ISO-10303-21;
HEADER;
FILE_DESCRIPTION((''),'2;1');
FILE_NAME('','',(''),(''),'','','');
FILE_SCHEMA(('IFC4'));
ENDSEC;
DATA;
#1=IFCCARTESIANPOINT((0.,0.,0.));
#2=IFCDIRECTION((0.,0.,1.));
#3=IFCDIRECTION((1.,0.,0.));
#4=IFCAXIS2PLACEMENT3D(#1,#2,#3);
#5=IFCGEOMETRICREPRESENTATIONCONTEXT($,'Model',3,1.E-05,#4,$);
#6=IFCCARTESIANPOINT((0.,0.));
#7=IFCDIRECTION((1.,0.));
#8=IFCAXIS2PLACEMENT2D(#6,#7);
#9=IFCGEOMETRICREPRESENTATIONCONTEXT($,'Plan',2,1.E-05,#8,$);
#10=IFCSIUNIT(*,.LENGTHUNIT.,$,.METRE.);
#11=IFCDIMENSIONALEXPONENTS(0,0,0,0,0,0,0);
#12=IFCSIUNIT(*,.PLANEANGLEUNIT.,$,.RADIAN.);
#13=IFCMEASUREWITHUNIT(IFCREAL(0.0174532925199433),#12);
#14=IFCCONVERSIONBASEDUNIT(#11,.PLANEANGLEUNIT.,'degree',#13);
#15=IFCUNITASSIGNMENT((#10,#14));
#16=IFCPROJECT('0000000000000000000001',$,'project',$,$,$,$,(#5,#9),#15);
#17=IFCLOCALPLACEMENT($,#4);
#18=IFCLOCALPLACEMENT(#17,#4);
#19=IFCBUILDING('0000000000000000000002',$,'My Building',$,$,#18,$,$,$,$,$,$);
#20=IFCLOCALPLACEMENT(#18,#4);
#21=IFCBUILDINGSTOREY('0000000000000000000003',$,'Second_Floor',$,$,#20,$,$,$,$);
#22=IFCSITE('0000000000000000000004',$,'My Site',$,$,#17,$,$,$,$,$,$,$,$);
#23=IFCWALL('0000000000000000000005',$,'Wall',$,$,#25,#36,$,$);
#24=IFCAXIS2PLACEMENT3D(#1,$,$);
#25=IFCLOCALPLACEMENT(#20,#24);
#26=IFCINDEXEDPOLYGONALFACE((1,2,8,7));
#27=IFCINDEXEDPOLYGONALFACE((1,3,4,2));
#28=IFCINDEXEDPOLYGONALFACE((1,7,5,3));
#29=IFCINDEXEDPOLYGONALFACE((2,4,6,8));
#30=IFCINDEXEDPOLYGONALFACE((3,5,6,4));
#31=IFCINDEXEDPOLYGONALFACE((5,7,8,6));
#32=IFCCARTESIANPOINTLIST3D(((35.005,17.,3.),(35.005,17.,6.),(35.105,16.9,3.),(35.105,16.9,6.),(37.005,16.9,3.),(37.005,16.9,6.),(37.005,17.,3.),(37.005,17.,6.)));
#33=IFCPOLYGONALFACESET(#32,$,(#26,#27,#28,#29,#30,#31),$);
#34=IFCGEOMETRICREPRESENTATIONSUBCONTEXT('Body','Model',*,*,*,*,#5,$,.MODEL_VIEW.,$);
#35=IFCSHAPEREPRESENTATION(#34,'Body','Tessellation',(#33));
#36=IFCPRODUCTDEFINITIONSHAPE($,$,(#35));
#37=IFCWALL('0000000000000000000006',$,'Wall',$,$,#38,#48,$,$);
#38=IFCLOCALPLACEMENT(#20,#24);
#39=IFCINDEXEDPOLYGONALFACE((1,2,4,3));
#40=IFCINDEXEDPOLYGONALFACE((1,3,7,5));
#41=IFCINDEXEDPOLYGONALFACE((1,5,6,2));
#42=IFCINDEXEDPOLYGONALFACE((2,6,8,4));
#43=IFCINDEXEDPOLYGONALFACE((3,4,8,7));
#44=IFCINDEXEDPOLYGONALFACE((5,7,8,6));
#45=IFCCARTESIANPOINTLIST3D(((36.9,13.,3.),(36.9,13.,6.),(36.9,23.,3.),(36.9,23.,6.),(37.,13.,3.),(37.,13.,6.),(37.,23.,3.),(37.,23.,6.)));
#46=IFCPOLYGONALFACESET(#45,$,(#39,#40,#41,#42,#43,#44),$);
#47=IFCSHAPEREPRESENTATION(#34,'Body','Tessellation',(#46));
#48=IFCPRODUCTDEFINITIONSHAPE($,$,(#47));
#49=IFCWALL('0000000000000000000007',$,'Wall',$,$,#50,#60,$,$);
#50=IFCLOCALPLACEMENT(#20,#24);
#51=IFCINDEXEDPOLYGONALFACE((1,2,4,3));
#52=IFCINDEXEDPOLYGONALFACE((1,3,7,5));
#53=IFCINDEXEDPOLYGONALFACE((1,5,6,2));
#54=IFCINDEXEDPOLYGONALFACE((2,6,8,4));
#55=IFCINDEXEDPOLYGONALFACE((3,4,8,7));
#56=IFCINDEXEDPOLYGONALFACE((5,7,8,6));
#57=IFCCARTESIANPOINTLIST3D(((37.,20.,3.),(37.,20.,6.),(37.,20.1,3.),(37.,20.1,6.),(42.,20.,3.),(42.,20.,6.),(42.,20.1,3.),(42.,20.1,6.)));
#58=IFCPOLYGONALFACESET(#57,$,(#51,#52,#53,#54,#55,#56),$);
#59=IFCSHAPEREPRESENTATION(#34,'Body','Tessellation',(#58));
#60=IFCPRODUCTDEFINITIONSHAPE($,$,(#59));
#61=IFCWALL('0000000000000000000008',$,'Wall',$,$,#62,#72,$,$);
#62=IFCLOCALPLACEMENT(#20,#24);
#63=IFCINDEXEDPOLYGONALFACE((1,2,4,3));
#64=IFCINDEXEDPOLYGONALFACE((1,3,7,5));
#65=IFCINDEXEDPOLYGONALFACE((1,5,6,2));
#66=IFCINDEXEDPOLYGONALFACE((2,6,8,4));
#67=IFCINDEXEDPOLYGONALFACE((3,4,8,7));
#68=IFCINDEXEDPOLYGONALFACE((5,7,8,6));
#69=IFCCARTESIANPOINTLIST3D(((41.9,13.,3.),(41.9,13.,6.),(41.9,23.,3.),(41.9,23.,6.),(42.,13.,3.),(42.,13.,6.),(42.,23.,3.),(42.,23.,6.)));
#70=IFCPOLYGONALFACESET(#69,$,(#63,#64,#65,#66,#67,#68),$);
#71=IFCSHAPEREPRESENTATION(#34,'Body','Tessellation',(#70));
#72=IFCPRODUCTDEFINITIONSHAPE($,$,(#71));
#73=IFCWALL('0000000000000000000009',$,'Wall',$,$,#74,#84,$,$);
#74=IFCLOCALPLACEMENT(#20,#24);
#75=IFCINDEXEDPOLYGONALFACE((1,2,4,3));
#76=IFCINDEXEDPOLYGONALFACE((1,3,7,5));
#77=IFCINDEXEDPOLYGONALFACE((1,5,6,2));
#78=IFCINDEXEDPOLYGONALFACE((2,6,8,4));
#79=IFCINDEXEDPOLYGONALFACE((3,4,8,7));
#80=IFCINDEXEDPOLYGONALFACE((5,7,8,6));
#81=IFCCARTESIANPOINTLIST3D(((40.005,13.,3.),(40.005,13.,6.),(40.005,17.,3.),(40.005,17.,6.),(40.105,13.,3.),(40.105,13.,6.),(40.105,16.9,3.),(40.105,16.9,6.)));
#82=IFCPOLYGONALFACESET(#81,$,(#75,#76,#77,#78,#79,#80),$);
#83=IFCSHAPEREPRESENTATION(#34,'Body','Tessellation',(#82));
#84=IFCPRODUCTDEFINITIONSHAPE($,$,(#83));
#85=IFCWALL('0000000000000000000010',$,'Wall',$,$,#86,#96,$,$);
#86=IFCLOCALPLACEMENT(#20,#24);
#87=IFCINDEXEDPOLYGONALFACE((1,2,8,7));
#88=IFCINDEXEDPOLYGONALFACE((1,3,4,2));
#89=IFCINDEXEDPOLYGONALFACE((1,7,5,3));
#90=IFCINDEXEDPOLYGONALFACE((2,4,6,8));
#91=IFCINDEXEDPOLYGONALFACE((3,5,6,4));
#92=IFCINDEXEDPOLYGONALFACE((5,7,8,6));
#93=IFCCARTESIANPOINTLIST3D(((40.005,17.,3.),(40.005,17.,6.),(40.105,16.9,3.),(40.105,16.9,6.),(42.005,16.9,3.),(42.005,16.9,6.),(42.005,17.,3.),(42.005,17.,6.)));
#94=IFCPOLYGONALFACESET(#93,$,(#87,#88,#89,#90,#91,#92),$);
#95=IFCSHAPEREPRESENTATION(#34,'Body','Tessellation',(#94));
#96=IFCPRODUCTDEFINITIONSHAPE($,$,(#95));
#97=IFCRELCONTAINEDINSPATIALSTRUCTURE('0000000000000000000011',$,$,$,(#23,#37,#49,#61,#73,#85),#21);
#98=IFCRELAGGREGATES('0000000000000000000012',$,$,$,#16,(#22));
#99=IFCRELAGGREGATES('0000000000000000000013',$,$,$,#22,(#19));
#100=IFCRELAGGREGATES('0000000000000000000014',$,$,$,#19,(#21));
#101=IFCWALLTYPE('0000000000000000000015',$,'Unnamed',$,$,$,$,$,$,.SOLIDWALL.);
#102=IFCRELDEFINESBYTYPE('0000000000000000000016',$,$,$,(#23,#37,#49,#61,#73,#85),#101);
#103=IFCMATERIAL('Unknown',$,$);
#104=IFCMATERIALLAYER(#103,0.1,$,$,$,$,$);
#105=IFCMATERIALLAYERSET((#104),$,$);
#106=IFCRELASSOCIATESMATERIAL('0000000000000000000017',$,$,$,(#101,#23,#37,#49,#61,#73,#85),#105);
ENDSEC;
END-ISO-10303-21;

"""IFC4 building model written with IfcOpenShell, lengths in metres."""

from ifc_helpers import new_model, entity, si_unit, converted_unit, frame, origin_with_axes, origin_2d_with_axis, place, context, subcontext, project, spatial, line, indexed_curve, outline, extrude, material, layer, layer_set, layer_usage, type_object, element, save


model = new_model("IFC4")

# Units and contexts
model_context = context("Model", 3, precision=1e-05, world=origin_with_axes())
plan_context = context("Plan", 2, precision=1e-05, world=origin_2d_with_axis())
body_context = subcontext(model_context, "Body", "Model", "MODEL_VIEW")
ifc_project = project(units=[si_unit("LENGTHUNIT", "METRE"), converted_unit("PLANEANGLEUNIT", "degree", entity("IfcReal", 0.0174532925199433), si_unit("PLANEANGLEUNIT", "RADIAN"), dimensions=[0, 0, 0, 0, 0, 0, 0])], contexts=[model_context, plan_context])

# Site, building, storey
site_placement = place(None, origin_with_axes())
site = spatial("IfcSite", under=ifc_project, at=site_placement, Name="My Site")
building_placement = place(site_placement, origin_with_axes())
building = spatial("IfcBuilding", under=site, at=building_placement, Name="My Building")
storey_placement = place(building_placement, origin_with_axes())
storey = spatial("IfcBuildingStorey", under=building, at=storey_placement, Name="Second_Floor")

# Walls
ifc_material = material(Name="Unknown")
ifc_layer = layer(ifc_material, 0.1)
ifc_layer_set = layer_set([ifc_layer])
wall_type = type_object("IfcWallType", Name="Unnamed", PredefinedType="SOLIDWALL", material=ifc_layer_set)
ifc_layer_usage_1 = layer_usage(ifc_layer_set, "AXIS2", "POSITIVE", 0.0)
wall_1_placement = place(storey_placement, frame((37.005, 17.0, 3.0), z_axis=(0.0, 0.0, 1.0), x_axis=(-1.0, 0.0, 0.0)))
element("IfcWall", 1, at=wall_1_placement, inside=storey, type_object=wall_type, material=ifc_layer_usage_1, Name="Wall", context=body_context, shape_type="SweptSolid", body=[
    extrude(outline(indexed_curve([(0.0, 0.0), (0.0, 0.1), (1.9, 0.1), (2.0, 0.0)], segments=[line(1, 2, 3, 4, 1)])), origin_with_axes(), (0.0, 0.0, 1.0), 3.0),
])
ifc_layer_usage_2 = layer_usage(ifc_layer_set, "AXIS2", "POSITIVE", 0.0)
wall_2_placement = place(storey_placement, frame((36.9, 23.0, 3.0), z_axis=(0.0, 0.0, 1.0), x_axis=(0.0, -1.0, 0.0)))
element("IfcWall", 2, at=wall_2_placement, inside=storey, type_object=wall_type, material=ifc_layer_usage_2, Name="Wall", context=body_context, shape_type="SweptSolid", body=[
    extrude(outline(indexed_curve([(0.0, 0.0), (0.0, 0.1), (10.0, 0.1), (10.0, 0.0)], segments=[line(1, 2, 3, 4, 1)])), origin_with_axes(), (0.0, 0.0, 1.0), 3.0),
])
ifc_layer_usage_3 = layer_usage(ifc_layer_set, "AXIS2", "POSITIVE", 0.0)
wall_3_placement = place(storey_placement, frame((37.0, 20.0, 3.0), z_axis=(0.0, 0.0, 1.0), x_axis=(1.0, 0.0, 0.0)))
element("IfcWall", 3, at=wall_3_placement, inside=storey, type_object=wall_type, material=ifc_layer_usage_3, Name="Wall", context=body_context, shape_type="SweptSolid", body=[
    extrude(outline(indexed_curve([(0.0, 0.0), (0.0, 0.1), (5.0, 0.1), (5.0, 0.0)], segments=[line(1, 2, 3, 4, 1)])), origin_with_axes(), (0.0, 0.0, 1.0), 3.0),
])
ifc_layer_usage_4 = layer_usage(ifc_layer_set, "AXIS2", "POSITIVE", 0.0)
wall_4_placement = place(storey_placement, frame((41.9, 23.0, 3.0), z_axis=(0.0, 0.0, 1.0), x_axis=(0.0, -1.0, 0.0)))
element("IfcWall", 4, at=wall_4_placement, inside=storey, type_object=wall_type, material=ifc_layer_usage_4, Name="Wall", context=body_context, shape_type="SweptSolid", body=[
    extrude(outline(indexed_curve([(0.0, 0.0), (0.0, 0.1), (10.0, 0.1), (10.0, 0.0)], segments=[line(1, 2, 3, 4, 1)])), origin_with_axes(), (0.0, 0.0, 1.0), 3.0),
])
ifc_layer_usage_5 = layer_usage(ifc_layer_set, "AXIS2", "POSITIVE", 0.0)
wall_5_placement = place(storey_placement, frame((40.005, 17.0, 3.0), z_axis=(0.0, 0.0, 1.0), x_axis=(0.0, -1.0, 0.0)))
element("IfcWall", 5, at=wall_5_placement, inside=storey, type_object=wall_type, material=ifc_layer_usage_5, Name="Wall", context=body_context, shape_type="SweptSolid", body=[
    extrude(outline(indexed_curve([(0.0, 0.0), (0.1, 0.1), (4.0, 0.1), (4.0, 0.0)], segments=[line(1, 2, 3, 4, 1)])), origin_with_axes(), (0.0, 0.0, 1.0), 3.0),
])
ifc_layer_usage_6 = layer_usage(ifc_layer_set, "AXIS2", "POSITIVE", 0.0)
wall_6_placement = place(storey_placement, frame((42.005, 17.0, 3.0), z_axis=(0.0, 0.0, 1.0), x_axis=(-1.0, 0.0, 0.0)))
element("IfcWall", 6, at=wall_6_placement, inside=storey, type_object=wall_type, material=ifc_layer_usage_6, Name="Wall", context=body_context, shape_type="SweptSolid", body=[
    extrude(outline(indexed_curve([(0.0, 0.0), (0.0, 0.1), (1.9, 0.1), (2.0, 0.0)], segments=[line(1, 2, 3, 4, 1)])), origin_with_axes(), (0.0, 0.0, 1.0), 3.0),
])

save(model, "model.ifc")
